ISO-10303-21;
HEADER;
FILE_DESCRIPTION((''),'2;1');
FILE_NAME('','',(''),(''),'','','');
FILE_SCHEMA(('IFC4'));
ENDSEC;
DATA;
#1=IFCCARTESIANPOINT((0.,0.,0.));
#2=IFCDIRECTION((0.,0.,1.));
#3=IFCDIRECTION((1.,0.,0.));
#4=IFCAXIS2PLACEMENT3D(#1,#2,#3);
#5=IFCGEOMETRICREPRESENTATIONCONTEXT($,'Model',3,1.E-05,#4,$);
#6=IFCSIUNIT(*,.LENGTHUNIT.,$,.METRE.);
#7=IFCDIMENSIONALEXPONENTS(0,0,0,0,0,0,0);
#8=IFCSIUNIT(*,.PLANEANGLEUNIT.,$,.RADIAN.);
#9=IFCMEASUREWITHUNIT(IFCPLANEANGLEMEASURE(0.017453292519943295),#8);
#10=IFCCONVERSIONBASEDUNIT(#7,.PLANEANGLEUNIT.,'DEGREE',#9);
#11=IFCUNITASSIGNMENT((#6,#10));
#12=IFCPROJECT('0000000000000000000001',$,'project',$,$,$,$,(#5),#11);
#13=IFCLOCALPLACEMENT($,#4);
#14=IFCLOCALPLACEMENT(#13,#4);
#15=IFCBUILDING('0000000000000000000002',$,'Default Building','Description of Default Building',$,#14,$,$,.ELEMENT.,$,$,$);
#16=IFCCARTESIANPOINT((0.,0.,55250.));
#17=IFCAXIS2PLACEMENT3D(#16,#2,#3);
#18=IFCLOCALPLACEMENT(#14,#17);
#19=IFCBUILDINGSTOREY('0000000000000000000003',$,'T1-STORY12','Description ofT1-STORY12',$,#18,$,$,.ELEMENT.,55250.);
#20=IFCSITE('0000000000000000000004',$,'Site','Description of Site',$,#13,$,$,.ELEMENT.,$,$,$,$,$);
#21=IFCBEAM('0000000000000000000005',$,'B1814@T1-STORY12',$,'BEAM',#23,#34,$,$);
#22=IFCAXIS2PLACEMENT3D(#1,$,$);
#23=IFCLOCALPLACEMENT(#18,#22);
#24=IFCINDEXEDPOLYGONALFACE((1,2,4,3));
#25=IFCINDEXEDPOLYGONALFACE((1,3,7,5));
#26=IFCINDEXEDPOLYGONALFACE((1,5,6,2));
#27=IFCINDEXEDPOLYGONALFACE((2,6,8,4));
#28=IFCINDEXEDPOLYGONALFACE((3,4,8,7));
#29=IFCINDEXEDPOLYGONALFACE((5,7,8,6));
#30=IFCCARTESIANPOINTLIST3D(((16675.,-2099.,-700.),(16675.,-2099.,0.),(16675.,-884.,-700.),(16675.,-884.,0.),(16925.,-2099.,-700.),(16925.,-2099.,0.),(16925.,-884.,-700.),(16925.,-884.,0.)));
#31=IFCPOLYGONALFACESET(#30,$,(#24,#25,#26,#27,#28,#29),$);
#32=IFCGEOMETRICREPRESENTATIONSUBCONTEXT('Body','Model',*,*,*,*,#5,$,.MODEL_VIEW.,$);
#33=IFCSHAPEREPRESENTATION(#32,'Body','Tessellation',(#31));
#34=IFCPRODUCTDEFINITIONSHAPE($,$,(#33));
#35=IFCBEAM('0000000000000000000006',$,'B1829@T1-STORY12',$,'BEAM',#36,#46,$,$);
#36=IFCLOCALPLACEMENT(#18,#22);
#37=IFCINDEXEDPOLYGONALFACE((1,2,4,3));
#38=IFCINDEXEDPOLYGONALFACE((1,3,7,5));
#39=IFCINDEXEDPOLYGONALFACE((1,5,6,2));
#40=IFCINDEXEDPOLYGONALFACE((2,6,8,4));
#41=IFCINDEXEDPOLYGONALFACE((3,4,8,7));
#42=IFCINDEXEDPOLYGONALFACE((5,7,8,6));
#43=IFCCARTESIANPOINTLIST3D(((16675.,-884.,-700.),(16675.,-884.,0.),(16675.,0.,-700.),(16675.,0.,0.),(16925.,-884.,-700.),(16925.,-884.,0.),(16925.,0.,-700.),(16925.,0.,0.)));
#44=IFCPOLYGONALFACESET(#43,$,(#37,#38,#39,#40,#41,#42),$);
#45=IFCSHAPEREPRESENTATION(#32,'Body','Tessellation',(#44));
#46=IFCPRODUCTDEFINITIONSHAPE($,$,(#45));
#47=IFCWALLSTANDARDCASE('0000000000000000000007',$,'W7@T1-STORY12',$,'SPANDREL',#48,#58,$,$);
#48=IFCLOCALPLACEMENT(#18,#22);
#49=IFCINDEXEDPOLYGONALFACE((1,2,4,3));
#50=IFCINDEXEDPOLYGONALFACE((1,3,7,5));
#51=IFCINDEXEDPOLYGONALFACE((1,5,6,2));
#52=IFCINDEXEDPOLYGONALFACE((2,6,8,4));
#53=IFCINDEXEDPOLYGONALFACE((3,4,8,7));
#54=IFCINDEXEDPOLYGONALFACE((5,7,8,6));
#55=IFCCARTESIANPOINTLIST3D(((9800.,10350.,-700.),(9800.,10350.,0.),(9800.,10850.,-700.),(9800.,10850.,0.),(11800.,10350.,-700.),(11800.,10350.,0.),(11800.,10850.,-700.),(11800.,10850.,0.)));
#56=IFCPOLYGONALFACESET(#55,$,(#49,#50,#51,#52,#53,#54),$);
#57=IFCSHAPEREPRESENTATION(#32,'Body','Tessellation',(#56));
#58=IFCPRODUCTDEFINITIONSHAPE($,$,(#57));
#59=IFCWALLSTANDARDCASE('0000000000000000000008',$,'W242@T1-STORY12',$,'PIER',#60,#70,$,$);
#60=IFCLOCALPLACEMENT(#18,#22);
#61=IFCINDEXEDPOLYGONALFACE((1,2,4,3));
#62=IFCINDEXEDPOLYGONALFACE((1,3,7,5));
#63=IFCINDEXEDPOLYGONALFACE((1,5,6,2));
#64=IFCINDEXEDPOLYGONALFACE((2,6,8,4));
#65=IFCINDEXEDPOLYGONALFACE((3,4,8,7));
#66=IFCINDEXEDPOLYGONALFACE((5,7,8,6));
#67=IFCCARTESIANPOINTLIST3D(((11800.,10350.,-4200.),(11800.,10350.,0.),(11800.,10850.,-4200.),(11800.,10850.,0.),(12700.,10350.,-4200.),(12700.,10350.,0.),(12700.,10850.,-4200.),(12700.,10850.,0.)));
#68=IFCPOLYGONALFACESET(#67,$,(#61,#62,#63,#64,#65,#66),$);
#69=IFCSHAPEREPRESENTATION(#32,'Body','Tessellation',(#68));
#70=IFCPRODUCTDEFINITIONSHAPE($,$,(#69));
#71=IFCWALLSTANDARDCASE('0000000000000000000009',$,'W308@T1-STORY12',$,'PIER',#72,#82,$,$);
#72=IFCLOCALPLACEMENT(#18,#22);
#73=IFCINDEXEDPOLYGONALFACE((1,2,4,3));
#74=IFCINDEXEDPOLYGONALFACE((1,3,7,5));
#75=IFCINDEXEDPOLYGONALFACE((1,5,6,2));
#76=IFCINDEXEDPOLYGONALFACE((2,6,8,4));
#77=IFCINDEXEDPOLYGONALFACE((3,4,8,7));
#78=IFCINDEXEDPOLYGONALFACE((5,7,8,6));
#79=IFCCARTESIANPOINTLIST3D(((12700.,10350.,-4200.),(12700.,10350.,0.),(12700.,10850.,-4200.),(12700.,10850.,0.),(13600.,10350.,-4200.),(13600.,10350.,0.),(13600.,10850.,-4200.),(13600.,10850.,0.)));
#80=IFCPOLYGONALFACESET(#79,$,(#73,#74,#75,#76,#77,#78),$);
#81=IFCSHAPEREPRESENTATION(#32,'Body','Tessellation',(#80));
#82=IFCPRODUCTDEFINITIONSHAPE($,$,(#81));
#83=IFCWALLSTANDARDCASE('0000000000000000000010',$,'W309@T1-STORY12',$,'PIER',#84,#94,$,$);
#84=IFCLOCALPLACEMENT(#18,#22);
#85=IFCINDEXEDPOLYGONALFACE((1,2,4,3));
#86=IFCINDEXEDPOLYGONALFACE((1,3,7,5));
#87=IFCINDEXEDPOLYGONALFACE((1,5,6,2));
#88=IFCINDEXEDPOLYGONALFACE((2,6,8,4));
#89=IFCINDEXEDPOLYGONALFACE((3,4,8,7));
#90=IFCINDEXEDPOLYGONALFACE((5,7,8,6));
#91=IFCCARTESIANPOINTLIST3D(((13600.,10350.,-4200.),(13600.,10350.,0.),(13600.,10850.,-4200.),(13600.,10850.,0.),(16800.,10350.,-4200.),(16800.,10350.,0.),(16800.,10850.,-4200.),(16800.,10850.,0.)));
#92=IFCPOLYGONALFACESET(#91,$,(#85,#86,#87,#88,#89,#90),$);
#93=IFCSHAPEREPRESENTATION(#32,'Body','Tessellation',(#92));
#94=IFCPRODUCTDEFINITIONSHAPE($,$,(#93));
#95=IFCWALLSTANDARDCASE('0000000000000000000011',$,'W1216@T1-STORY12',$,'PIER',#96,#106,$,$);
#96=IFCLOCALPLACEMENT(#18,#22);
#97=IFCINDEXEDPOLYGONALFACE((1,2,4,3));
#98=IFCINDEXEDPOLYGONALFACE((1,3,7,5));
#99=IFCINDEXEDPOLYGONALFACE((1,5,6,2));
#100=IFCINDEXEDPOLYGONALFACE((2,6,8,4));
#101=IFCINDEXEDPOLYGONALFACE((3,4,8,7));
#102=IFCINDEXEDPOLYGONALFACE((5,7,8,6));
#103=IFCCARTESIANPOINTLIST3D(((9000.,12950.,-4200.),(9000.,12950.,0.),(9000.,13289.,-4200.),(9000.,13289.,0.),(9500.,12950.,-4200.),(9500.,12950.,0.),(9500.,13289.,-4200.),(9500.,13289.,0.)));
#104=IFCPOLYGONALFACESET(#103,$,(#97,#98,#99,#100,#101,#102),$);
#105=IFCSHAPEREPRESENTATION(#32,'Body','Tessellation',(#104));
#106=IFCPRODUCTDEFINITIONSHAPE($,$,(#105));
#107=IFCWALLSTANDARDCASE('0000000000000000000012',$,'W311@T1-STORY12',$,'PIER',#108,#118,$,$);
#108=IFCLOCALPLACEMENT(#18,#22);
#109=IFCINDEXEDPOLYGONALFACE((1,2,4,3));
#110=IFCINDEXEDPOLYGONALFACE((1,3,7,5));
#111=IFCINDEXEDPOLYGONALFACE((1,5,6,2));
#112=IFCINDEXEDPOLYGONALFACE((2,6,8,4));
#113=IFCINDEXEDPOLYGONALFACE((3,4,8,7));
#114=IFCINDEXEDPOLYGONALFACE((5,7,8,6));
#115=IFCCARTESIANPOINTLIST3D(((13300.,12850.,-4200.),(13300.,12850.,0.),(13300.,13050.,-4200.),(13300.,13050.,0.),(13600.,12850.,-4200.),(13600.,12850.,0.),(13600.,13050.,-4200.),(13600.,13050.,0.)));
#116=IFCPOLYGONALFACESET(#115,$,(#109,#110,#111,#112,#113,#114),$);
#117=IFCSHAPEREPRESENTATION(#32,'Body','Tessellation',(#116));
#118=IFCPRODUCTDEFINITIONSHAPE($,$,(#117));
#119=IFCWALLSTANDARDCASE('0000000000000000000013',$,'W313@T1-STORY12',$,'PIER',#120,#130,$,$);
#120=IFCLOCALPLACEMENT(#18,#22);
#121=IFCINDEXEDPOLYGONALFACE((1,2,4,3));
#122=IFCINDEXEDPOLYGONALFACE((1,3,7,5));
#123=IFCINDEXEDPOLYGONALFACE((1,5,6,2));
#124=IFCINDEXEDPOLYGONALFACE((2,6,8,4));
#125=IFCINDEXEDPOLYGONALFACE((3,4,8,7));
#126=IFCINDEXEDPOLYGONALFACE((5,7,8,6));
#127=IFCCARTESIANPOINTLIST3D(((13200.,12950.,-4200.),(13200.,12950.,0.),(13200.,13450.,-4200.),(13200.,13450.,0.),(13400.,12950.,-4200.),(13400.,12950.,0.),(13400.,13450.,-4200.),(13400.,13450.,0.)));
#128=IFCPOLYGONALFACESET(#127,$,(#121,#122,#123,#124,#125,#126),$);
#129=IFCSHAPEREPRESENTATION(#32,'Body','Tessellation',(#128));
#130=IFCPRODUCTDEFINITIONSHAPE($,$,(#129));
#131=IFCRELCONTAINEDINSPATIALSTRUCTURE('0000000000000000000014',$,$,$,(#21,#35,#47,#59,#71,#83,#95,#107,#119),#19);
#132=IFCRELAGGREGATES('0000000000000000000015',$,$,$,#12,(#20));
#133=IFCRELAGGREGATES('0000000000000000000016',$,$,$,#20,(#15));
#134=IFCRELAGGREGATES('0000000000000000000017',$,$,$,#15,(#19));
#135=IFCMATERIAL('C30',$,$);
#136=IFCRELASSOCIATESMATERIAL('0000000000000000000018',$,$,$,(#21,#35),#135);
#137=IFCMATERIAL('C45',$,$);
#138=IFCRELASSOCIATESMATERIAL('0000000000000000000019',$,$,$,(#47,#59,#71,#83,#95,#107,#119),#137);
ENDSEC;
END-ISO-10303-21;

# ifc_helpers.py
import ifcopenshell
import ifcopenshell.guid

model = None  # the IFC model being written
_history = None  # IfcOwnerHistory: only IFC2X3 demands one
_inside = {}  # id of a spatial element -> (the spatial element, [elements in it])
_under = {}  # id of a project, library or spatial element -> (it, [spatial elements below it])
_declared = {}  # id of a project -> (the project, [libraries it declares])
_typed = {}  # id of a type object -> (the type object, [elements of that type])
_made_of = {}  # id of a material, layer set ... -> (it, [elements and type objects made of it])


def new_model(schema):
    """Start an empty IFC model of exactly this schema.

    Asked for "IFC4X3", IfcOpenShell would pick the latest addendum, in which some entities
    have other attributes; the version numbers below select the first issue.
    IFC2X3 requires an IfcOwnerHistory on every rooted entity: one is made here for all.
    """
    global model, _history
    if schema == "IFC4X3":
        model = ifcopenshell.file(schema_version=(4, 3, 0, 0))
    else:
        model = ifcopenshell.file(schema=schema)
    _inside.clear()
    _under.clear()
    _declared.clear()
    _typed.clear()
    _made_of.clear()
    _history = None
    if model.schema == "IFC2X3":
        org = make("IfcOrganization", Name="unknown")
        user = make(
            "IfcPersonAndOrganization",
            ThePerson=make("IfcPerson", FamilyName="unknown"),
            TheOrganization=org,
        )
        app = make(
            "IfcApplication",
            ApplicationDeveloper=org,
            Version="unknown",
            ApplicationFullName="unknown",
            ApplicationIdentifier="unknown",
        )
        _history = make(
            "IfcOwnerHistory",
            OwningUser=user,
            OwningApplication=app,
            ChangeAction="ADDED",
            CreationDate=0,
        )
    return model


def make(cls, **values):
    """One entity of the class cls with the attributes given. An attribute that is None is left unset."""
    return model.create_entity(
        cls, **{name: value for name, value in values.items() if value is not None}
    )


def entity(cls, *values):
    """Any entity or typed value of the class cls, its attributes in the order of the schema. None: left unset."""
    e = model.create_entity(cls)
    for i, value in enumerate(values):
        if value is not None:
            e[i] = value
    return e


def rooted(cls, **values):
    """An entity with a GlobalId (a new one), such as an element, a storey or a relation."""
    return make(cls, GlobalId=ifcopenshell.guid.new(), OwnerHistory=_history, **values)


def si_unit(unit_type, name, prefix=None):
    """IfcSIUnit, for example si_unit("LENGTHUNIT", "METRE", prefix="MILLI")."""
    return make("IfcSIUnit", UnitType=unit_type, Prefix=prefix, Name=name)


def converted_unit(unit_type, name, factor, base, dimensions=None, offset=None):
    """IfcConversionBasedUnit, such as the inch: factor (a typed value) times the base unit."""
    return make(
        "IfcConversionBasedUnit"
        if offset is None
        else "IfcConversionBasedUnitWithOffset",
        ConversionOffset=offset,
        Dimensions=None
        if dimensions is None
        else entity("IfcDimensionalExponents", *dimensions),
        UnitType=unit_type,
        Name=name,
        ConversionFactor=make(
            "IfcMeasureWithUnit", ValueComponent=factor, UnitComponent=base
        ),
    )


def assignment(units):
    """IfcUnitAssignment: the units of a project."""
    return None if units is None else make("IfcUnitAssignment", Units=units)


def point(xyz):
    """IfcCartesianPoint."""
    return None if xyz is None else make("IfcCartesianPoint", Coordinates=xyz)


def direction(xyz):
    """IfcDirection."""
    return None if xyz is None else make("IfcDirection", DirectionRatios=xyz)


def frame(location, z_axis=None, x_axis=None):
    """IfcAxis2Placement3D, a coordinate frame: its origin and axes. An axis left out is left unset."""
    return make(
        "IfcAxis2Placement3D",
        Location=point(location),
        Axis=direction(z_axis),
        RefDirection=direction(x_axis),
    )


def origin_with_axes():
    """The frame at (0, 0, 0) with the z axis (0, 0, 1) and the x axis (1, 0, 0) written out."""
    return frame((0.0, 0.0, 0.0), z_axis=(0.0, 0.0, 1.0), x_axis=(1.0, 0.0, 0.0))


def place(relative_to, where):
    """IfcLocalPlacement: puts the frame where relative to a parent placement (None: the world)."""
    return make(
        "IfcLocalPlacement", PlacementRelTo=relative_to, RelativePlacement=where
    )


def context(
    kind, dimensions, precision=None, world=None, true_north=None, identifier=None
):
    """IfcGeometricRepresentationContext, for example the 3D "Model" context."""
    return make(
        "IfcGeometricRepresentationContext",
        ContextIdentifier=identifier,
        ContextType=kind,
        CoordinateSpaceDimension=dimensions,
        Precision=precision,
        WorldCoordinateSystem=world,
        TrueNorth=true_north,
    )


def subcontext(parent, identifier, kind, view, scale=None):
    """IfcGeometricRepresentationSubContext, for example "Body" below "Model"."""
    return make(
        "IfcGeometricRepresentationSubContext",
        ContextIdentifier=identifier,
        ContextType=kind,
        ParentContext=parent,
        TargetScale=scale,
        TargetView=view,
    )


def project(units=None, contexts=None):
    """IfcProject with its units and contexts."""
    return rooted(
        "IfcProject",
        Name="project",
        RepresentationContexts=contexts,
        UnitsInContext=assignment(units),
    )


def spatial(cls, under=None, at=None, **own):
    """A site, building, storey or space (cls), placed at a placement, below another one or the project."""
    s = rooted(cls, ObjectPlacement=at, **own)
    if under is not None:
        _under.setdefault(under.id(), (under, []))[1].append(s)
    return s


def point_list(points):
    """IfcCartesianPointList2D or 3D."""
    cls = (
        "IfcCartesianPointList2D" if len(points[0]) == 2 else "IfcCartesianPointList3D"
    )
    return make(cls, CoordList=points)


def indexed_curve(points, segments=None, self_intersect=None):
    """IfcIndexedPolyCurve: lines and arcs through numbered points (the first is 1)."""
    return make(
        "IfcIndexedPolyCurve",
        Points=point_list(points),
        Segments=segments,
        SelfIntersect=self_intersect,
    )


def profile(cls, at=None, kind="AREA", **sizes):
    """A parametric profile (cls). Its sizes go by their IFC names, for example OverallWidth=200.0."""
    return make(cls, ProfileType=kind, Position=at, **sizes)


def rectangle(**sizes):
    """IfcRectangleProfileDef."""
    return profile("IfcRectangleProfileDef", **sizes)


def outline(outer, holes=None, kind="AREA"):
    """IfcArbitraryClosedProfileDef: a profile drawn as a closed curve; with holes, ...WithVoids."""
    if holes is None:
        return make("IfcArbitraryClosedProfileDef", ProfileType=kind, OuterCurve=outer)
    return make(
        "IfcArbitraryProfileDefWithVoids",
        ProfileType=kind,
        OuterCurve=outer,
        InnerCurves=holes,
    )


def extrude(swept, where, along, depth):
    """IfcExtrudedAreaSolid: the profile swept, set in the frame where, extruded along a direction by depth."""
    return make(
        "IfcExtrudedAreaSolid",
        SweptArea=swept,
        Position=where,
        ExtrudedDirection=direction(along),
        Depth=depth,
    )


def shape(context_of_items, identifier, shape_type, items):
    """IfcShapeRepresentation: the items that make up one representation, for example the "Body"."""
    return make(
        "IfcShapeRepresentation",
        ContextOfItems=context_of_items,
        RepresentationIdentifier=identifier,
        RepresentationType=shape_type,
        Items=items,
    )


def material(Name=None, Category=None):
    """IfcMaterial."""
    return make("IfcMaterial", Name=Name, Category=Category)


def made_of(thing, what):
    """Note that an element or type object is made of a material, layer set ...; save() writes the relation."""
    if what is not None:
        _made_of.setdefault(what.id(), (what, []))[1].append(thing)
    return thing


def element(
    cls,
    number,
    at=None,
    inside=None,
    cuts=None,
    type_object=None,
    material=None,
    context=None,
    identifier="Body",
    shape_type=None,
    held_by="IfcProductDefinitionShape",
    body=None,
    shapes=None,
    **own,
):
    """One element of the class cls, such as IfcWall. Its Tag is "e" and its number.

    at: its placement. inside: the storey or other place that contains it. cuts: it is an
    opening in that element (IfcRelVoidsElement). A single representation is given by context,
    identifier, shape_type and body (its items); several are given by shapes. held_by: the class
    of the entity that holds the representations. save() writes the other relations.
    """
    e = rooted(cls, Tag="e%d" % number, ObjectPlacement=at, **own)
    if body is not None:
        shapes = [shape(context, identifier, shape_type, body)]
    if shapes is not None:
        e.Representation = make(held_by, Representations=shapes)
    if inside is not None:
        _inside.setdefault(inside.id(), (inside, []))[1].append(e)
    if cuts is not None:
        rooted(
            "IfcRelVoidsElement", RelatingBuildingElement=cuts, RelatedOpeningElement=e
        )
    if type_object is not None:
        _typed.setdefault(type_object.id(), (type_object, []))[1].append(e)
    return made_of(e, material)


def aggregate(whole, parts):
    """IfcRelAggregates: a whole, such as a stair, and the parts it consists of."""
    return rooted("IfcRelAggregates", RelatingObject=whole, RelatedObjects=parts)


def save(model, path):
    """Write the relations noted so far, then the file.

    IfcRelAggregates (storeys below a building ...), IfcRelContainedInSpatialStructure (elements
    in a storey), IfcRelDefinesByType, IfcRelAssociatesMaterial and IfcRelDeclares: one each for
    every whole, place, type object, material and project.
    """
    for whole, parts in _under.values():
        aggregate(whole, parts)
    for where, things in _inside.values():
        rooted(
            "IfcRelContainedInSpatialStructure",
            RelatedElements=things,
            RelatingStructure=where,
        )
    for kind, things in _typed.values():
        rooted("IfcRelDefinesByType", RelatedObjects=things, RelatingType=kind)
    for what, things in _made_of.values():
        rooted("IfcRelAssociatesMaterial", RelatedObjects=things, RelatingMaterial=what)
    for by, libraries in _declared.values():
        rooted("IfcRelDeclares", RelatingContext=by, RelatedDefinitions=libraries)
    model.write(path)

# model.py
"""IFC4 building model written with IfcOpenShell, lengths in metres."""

from ifc_helpers import new_model, entity, si_unit, converted_unit, frame, origin_with_axes, place, context, subcontext, project, spatial, indexed_curve, rectangle, outline, extrude, material, element, save


model = new_model("IFC4")

# Units and contexts
model_context = context("Model", 3, precision=1e-05, world=origin_with_axes())
body_context = subcontext(model_context, "Body", "Model", "MODEL_VIEW")
ifc_project = project(units=[si_unit("LENGTHUNIT", "METRE"), converted_unit("PLANEANGLEUNIT", "DEGREE", entity("IfcPlaneAngleMeasure", 0.017453292519943295), si_unit("PLANEANGLEUNIT", "RADIAN"), dimensions=[0, 0, 0, 0, 0, 0, 0])], contexts=[model_context])

# Site, building, storey
site_placement = place(None, origin_with_axes())
site = spatial("IfcSite", under=ifc_project, at=site_placement, Name="Site", Description="Description of Site", CompositionType="ELEMENT")
building_placement = place(site_placement, origin_with_axes())
building = spatial("IfcBuilding", under=site, at=building_placement, Name="Default Building", Description="Description of Default Building", CompositionType="ELEMENT")
storey_placement = place(building_placement, frame((0.0, 0.0, 55250.0), z_axis=(0.0, 0.0, 1.0), x_axis=(1.0, 0.0, 0.0)))
storey = spatial("IfcBuildingStorey", under=building, at=storey_placement, Name="T1-STORY12", Description="Description ofT1-STORY12", CompositionType="ELEMENT", Elevation=55250.0)

# Beams
ifc_material_1 = material(Name="C30")
beam_1_placement = place(storey_placement, frame((16800.0, -2099.0, -350.0), z_axis=(0.0, 1.0, 0.0), x_axis=(-1.0, 0.0, 0.0)))
element("IfcBeam", 1, at=beam_1_placement, inside=storey, material=ifc_material_1, Name="B1814@T1-STORY12", ObjectType="BEAM", context=body_context, shape_type="SweptSolid", body=[
    extrude(rectangle(XDim=250.0, YDim=700.0), origin_with_axes(), (0.0, 0.0, 1.0), 1215.0),
])
beam_2_placement = place(storey_placement, frame((16800.0, -884.0, -350.0), z_axis=(0.0, 1.0, 0.0), x_axis=(-1.0, 0.0, 0.0)))
element("IfcBeam", 2, at=beam_2_placement, inside=storey, material=ifc_material_1, Name="B1829@T1-STORY12", ObjectType="BEAM", context=body_context, shape_type="SweptSolid", body=[
    extrude(rectangle(XDim=250.0, YDim=700.0), origin_with_axes(), (0.0, 0.0, 1.0), 884.0),
])
ifc_material_2 = material(Name="C45")

# Walls
wall_1_placement = place(storey_placement, frame((9800.0, 10600.0, -700.0), z_axis=(0.0, 0.0, 1.0), x_axis=(1.0, 0.0, 0.0)))
element("IfcWallStandardCase", 3, at=wall_1_placement, inside=storey, material=ifc_material_2, Name="W7@T1-STORY12", ObjectType="SPANDREL", context=body_context, shape_type="SweptSolid", body=[
    extrude(outline(indexed_curve([(0.0, -250.0), (0.0, 250.0), (2000.0, 250.0), (2000.0, -250.0), (0.0, -250.0)], self_intersect=False)), origin_with_axes(), (0.0, 0.0, 1.0), 700.0),
])
for number, where, z_axis, x_axis, name in (
    (4, (11800.0, 10600.0, -4200.0), (0.0, 0.0, 1.0), (1.0, 0.0, 0.0), "W242@T1-STORY12"),
    (5, (12700.0, 10600.0, -4200.0), (0.0, 0.0, 1.0), (1.0, 0.0, 0.0), "W308@T1-STORY12"),
):
    element("IfcWallStandardCase", number, at=place(storey_placement, frame(where, z_axis=z_axis, x_axis=x_axis)), inside=storey, material=ifc_material_2, Name=name, ObjectType="PIER", context=body_context, shape_type="SweptSolid", body=[
        extrude(outline(indexed_curve([(0.0, -250.0), (0.0, 250.0), (900.0, 250.0), (900.0, -250.0), (0.0, -250.0)], self_intersect=False)), origin_with_axes(), (0.0, 0.0, 1.0), 4200.0),
    ])
wall_2_placement = place(storey_placement, frame((13600.0, 10600.0, -4200.0), z_axis=(0.0, 0.0, 1.0), x_axis=(1.0, 0.0, 0.0)))
element("IfcWallStandardCase", 6, at=wall_2_placement, inside=storey, material=ifc_material_2, Name="W309@T1-STORY12", ObjectType="PIER", context=body_context, shape_type="SweptSolid", body=[
    extrude(outline(indexed_curve([(0.0, -250.0), (0.0, 250.0), (3200.0, 250.0), (3200.0, -250.0), (0.0, -250.0)], self_intersect=False)), origin_with_axes(), (0.0, 0.0, 1.0), 4200.0),
])
wall_3_placement = place(storey_placement, frame((9250.0, 12950.0, -4200.0), z_axis=(0.0, 0.0, 1.0), x_axis=(0.0, 1.0, 0.0)))
element("IfcWallStandardCase", 7, at=wall_3_placement, inside=storey, material=ifc_material_2, Name="W1216@T1-STORY12", ObjectType="PIER", context=body_context, shape_type="SweptSolid", body=[
    extrude(outline(indexed_curve([(0.0, -250.0), (0.0, 250.0), (339.0, 250.0), (339.0, -250.0), (0.0, -250.0)], self_intersect=False)), origin_with_axes(), (0.0, 0.0, 1.0), 4200.0),
])
wall_4_placement = place(storey_placement, frame((13300.0, 12950.0, -4200.0), z_axis=(0.0, 0.0, 1.0), x_axis=(1.0, 0.0, 0.0)))
element("IfcWallStandardCase", 8, at=wall_4_placement, inside=storey, material=ifc_material_2, Name="W311@T1-STORY12", ObjectType="PIER", context=body_context, shape_type="SweptSolid", body=[
    extrude(outline(indexed_curve([(0.0, -100.0), (0.0, 100.0), (300.0, 100.0), (300.0, -100.0), (0.0, -100.0)], self_intersect=False)), origin_with_axes(), (0.0, 0.0, 1.0), 4200.0),
])
wall_5_placement = place(storey_placement, frame((13300.0, 12950.0, -4200.0), z_axis=(0.0, 0.0, 1.0), x_axis=(0.0, 1.0, 0.0)))
element("IfcWallStandardCase", 9, at=wall_5_placement, inside=storey, material=ifc_material_2, Name="W313@T1-STORY12", ObjectType="PIER", context=body_context, shape_type="SweptSolid", body=[
    extrude(outline(indexed_curve([(0.0, -100.0), (0.0, 100.0), (500.0, 100.0), (500.0, -100.0), (0.0, -100.0)], self_intersect=False)), origin_with_axes(), (0.0, 0.0, 1.0), 4200.0),
])

save(model, "model.ifc")
